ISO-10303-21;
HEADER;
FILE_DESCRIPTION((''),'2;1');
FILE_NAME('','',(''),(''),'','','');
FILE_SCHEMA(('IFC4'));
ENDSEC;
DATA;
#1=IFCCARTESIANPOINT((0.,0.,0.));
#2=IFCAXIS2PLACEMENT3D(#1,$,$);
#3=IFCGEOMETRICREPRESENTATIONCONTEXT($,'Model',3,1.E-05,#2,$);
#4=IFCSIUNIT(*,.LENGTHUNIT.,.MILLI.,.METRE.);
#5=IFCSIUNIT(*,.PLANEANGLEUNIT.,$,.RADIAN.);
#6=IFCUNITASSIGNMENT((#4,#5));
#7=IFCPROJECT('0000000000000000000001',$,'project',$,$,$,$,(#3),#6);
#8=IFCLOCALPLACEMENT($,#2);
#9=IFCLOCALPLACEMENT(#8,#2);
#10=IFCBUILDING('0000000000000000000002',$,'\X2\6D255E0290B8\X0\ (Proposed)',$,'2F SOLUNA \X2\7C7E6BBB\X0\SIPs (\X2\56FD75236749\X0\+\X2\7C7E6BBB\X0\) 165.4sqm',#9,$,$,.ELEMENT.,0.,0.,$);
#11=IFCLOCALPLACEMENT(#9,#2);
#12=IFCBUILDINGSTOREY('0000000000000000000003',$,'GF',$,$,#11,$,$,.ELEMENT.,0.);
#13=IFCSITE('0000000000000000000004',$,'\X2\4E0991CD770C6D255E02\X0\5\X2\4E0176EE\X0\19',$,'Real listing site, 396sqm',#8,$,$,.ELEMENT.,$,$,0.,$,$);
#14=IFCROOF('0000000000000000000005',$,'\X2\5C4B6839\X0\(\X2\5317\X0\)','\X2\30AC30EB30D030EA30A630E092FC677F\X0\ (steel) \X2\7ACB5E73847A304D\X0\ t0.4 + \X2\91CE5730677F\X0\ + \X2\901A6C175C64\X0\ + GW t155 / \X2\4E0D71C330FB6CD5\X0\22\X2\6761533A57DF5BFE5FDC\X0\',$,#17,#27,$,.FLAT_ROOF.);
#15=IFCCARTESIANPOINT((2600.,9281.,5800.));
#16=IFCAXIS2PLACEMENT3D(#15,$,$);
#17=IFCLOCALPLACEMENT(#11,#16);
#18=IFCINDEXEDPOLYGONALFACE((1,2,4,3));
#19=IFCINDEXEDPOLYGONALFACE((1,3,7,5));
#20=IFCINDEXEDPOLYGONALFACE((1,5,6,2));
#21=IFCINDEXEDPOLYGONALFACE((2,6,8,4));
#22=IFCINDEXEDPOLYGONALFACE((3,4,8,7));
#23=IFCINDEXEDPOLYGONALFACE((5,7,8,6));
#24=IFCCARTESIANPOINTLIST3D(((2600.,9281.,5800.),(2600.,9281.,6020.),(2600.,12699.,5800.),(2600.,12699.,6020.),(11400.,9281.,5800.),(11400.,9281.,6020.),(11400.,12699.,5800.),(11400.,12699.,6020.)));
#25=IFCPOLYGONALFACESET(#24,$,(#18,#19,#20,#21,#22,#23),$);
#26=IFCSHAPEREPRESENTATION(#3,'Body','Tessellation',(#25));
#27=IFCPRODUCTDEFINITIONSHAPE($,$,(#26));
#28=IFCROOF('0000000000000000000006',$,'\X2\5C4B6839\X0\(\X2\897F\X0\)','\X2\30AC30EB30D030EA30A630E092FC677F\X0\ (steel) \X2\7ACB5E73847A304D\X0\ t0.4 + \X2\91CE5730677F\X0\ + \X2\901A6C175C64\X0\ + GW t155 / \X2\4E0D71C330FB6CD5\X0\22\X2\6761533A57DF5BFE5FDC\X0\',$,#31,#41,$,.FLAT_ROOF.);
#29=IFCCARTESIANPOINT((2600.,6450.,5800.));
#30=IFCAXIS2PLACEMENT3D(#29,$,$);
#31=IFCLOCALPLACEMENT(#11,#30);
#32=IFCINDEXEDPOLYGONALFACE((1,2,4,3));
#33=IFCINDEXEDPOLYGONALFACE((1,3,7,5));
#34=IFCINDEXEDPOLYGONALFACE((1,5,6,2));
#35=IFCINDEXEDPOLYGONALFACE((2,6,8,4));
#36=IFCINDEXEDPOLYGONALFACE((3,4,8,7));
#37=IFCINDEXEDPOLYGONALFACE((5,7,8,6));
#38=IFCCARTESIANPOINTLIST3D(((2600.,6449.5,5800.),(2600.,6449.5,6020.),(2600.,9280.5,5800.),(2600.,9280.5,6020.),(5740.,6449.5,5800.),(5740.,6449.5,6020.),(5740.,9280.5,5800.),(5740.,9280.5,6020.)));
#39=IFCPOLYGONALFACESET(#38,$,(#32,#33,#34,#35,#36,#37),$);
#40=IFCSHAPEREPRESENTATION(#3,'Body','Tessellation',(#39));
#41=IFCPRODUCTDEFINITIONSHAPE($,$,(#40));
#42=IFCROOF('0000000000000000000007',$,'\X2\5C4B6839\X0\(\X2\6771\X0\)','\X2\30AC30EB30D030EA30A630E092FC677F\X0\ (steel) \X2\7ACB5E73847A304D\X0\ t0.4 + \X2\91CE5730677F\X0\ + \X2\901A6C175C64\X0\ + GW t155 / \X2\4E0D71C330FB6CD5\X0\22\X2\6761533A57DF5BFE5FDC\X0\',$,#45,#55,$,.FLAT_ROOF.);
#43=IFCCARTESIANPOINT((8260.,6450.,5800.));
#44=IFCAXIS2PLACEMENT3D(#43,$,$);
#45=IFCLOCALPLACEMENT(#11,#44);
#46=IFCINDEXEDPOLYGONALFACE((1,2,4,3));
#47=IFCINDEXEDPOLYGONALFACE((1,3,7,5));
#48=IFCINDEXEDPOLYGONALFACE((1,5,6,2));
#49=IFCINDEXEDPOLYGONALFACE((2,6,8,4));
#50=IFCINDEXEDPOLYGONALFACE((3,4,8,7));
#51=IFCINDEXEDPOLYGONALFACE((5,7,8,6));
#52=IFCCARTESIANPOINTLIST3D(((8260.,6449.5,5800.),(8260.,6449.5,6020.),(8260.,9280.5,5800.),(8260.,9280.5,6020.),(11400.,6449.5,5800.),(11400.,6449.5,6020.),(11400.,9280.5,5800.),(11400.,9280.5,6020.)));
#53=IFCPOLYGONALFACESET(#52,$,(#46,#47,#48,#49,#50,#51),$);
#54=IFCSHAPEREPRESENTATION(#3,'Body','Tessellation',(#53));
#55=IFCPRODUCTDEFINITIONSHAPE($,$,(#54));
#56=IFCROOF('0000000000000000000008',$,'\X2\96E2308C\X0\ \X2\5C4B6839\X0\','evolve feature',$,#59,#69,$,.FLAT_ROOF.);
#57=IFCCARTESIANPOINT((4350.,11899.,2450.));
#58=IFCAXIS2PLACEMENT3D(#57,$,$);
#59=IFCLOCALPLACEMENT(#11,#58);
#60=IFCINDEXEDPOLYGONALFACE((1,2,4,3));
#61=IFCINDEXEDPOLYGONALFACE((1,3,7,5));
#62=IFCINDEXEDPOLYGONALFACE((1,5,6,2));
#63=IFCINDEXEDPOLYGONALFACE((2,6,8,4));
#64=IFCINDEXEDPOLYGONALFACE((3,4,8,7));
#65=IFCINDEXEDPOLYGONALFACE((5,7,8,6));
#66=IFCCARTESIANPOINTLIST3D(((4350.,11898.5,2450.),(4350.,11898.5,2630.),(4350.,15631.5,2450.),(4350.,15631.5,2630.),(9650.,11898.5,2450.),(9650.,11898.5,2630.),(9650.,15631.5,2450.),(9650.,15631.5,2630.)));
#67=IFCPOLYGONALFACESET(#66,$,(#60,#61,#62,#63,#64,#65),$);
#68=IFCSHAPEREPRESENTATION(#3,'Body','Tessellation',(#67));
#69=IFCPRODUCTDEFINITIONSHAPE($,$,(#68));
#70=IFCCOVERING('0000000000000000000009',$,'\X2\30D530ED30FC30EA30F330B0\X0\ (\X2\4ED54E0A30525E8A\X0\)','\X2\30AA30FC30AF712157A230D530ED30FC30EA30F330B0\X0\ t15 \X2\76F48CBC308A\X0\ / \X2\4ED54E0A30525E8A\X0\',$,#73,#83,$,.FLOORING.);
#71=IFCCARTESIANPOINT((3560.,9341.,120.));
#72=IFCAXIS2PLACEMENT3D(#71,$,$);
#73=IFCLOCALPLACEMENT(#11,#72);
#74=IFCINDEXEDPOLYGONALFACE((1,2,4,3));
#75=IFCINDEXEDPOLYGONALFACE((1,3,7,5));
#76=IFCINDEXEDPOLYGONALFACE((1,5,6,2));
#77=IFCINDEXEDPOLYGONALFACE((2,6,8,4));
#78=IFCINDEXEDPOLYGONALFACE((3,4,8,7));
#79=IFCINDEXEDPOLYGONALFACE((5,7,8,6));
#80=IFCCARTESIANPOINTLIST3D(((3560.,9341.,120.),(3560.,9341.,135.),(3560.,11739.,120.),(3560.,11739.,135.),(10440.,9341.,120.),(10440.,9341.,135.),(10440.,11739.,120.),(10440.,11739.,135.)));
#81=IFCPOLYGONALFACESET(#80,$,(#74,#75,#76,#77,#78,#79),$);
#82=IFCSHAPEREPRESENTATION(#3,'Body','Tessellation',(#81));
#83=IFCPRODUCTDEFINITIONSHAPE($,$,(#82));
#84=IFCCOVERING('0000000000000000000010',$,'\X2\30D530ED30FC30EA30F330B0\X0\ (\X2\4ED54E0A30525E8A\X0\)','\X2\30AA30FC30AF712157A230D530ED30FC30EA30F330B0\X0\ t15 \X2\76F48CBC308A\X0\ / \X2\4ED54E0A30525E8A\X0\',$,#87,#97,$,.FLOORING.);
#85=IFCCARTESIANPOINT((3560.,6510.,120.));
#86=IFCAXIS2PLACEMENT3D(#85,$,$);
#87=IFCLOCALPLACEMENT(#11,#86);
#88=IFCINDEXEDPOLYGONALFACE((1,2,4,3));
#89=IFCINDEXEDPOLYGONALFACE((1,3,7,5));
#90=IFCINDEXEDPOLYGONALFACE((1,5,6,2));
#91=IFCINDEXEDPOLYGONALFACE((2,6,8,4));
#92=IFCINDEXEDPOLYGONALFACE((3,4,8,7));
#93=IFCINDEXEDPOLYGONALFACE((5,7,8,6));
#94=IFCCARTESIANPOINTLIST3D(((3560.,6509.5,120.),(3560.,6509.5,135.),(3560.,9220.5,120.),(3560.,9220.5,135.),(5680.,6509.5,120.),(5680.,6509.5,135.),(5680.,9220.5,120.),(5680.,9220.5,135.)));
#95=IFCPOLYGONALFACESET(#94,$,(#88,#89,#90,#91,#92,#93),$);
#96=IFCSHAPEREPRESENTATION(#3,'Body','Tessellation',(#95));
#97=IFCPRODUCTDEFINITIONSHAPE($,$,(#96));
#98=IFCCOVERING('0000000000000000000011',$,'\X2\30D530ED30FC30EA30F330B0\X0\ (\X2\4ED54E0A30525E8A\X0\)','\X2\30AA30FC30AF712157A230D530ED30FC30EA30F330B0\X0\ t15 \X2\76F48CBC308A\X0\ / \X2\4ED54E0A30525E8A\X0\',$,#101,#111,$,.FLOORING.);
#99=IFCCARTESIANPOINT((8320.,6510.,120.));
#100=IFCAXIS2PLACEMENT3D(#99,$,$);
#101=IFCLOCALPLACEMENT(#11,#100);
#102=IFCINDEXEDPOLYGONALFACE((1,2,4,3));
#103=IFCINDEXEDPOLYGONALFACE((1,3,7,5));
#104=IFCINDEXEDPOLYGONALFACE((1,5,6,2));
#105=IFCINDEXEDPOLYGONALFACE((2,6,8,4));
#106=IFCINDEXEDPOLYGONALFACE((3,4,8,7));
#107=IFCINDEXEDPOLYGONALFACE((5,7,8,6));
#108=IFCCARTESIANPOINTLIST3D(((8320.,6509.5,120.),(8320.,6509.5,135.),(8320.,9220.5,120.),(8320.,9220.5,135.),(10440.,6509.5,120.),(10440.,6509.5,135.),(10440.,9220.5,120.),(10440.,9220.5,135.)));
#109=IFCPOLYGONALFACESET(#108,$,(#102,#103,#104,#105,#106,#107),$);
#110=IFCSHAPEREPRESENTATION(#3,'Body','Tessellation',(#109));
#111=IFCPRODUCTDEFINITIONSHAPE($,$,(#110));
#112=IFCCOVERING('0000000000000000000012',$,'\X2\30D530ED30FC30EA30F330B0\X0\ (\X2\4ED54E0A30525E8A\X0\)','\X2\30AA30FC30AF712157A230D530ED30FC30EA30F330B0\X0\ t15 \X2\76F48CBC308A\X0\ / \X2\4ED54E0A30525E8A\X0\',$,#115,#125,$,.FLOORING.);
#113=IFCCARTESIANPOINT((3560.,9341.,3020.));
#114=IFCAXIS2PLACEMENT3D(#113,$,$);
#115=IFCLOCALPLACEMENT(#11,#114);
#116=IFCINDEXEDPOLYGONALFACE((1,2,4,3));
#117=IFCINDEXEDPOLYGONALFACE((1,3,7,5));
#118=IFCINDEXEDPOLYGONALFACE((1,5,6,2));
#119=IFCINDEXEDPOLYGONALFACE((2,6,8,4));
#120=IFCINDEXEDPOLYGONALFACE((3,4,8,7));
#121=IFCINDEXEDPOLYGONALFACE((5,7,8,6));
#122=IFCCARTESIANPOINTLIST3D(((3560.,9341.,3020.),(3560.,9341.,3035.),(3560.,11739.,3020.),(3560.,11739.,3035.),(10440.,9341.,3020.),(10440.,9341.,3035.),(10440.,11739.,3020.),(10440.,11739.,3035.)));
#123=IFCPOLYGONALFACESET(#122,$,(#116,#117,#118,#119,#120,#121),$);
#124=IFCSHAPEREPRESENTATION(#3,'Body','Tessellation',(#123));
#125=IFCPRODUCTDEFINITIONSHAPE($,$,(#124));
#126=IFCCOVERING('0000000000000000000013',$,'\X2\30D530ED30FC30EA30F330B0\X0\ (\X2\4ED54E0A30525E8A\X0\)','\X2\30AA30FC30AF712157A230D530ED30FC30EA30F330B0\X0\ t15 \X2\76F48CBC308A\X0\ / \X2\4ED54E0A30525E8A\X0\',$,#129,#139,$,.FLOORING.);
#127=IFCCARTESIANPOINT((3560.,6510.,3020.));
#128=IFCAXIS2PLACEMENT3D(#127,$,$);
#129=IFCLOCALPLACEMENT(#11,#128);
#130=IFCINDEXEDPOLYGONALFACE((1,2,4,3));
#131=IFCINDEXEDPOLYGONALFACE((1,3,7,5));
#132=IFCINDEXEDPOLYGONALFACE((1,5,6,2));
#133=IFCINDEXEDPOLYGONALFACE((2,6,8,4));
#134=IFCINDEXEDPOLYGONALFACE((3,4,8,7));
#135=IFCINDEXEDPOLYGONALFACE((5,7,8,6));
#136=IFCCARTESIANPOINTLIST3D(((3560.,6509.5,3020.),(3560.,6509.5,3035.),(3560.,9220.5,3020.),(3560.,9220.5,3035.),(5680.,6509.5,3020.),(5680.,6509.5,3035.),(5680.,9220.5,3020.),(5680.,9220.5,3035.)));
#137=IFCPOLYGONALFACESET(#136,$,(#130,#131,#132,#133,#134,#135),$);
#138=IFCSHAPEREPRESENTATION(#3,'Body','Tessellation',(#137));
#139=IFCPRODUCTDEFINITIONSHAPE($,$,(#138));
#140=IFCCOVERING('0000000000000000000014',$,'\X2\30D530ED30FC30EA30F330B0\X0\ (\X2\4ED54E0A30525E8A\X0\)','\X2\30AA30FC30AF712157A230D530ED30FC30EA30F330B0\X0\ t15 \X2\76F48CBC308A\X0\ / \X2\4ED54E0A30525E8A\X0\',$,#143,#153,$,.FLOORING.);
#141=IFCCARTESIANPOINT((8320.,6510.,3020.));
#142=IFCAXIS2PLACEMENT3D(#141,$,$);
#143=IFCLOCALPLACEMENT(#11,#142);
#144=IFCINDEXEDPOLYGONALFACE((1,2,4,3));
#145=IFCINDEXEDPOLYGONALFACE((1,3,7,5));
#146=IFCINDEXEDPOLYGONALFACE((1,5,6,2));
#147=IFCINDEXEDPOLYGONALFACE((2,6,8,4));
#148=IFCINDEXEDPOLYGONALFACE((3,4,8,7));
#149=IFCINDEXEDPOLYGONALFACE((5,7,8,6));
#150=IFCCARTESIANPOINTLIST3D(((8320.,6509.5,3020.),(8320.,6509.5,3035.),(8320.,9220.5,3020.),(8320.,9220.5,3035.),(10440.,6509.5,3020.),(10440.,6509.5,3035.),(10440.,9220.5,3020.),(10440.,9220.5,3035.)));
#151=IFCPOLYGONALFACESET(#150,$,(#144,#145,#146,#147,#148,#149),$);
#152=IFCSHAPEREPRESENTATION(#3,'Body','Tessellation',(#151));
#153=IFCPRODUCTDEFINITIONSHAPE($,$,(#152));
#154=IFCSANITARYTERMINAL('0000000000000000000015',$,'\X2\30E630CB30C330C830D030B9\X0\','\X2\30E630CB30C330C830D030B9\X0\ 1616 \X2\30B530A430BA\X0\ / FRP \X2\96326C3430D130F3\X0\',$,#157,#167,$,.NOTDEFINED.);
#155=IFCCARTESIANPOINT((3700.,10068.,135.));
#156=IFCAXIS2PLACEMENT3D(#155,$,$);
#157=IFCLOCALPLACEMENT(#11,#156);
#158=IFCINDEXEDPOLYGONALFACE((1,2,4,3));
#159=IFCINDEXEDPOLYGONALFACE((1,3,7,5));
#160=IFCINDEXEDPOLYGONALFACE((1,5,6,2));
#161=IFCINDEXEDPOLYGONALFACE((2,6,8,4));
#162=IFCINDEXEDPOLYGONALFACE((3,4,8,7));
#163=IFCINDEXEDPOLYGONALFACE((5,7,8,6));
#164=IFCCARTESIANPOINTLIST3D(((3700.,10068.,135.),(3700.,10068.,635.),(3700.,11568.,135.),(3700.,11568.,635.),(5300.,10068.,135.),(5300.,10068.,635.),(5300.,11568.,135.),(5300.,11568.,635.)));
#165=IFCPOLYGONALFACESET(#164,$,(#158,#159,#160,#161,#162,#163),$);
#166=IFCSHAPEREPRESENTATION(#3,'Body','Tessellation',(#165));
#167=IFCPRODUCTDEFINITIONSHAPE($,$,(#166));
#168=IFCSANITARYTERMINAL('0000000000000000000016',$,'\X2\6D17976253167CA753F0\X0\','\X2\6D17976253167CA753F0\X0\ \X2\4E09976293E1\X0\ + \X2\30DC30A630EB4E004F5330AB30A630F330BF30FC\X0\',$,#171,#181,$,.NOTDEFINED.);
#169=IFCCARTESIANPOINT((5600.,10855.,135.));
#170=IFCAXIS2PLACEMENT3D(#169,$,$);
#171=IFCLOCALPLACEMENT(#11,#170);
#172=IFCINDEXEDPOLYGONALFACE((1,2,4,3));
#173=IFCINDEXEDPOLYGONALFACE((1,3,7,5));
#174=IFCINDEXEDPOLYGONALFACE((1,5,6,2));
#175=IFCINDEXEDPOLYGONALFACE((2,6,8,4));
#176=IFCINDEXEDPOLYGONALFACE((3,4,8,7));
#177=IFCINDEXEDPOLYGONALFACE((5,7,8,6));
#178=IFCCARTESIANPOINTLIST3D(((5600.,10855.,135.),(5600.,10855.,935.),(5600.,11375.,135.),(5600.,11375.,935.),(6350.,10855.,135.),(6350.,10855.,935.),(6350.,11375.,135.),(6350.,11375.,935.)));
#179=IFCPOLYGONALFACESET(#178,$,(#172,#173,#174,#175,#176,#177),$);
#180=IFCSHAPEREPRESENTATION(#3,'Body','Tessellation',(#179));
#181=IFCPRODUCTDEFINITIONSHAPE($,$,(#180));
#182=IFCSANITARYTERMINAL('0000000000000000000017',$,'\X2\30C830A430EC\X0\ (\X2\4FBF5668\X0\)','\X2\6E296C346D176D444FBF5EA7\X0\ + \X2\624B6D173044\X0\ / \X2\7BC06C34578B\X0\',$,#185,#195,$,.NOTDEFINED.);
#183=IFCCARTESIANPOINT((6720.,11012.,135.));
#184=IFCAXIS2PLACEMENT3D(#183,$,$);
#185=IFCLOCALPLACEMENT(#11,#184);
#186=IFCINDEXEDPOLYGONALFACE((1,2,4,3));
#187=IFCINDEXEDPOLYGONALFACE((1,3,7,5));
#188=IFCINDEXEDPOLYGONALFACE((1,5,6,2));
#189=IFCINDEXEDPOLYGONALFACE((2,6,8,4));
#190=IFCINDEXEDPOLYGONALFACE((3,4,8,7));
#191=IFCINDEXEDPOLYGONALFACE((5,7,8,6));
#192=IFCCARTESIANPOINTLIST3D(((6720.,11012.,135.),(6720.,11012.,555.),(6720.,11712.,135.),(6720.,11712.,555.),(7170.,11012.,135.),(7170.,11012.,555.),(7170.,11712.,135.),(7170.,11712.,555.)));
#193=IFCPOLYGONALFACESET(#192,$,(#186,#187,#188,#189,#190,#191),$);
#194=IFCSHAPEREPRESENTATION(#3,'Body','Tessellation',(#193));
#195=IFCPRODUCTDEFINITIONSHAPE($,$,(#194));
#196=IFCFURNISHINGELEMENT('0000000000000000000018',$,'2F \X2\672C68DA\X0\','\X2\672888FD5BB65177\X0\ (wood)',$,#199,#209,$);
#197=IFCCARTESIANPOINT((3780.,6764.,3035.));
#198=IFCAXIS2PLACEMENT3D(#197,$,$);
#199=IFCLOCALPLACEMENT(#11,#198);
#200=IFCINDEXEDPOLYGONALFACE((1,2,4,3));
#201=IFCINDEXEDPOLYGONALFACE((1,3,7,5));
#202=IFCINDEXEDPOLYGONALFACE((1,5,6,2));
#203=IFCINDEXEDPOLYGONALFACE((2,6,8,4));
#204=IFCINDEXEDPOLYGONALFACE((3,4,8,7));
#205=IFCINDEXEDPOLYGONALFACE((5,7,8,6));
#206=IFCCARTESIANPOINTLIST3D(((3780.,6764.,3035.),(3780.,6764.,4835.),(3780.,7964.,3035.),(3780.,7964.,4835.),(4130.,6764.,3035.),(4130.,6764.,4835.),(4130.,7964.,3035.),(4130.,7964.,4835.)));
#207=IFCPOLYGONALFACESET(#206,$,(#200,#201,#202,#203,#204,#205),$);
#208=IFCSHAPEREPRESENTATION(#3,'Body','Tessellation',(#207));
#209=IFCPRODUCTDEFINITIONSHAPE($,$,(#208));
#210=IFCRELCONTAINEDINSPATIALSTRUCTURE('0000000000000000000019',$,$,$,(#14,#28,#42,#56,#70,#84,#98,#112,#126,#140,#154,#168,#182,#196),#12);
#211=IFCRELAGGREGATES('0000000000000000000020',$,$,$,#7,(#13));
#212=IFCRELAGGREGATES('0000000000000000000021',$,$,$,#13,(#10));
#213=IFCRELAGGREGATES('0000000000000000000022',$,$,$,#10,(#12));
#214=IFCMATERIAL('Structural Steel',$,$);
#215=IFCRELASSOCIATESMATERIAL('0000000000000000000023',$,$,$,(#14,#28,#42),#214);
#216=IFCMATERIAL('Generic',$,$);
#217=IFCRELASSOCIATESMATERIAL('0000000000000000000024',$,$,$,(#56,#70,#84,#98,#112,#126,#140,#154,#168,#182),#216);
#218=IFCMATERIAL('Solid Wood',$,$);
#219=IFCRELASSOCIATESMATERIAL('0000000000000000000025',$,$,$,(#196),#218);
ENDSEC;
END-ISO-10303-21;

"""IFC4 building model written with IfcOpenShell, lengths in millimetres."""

from ifc_helpers import new_model, si_unit, frame, frame_2d, origin, place, context, project, spatial, rectangle, extrude, material, element, save


model = new_model("IFC4")

# Units and contexts
model_context = context("Model", 3, precision=1e-05, world=origin())
ifc_project = project(units=[si_unit("LENGTHUNIT", "METRE", prefix="MILLI"), si_unit("PLANEANGLEUNIT", "RADIAN")], contexts=[model_context])

# Site, building, storey
site_placement = place(None, origin())
site = spatial("IfcSite", under=ifc_project, at=site_placement, Name="三重県津市5丁目19", ObjectType="Real listing site, 396sqm", CompositionType="ELEMENT", RefElevation=0.0)
building_placement = place(site_placement, origin())
building = spatial("IfcBuilding", under=site, at=building_placement, Name="津市邸 (Proposed)", ObjectType="2F SOLUNA 籾殻SIPs (国産杉+籾殻) 165.4sqm", CompositionType="ELEMENT", ElevationOfRefHeight=0.0, ElevationOfTerrain=0.0)
storey_placement = place(building_placement, origin())
storey = spatial("IfcBuildingStorey", under=building, at=storey_placement, Name="GF", CompositionType="ELEMENT", Elevation=0.0)

# Shared definitions
ifc_material_1 = material(Name="Solid Wood")
ifc_material_2 = material(Name="Generic")

# Roofs
ifc_material_3 = material(Name="Structural Steel")
for number, where, name in (
    (1, (2600.0, 9281.0, 5800.0), "屋根(北)"),
):
    element("IfcRoof", number, at=place(storey_placement, frame(where)), inside=storey, material=ifc_material_3, Name=name, Description="ガルバリウム鋼板 (steel) 立平葺き t0.4 + 野地板 + 通気層 + GW t155 / 不燃・法22条区域対応", PredefinedType="FLAT_ROOF", context=model_context, shape_type="SweptSolid", body=[
        extrude(rectangle(XDim=8800.0, YDim=3418.0, at=frame_2d((4400.0, 1709.0))), frame((2600.0, 9281.0, 5800.0)), (0.0, 0.0, 1.0), 220.0),
    ])
roof_1_placement = place(storey_placement, frame((2600.0, 6450.0, 5800.0)))
element("IfcRoof", 2, at=roof_1_placement, inside=storey, material=ifc_material_3, Name="屋根(西)", Description="ガルバリウム鋼板 (steel) 立平葺き t0.4 + 野地板 + 通気層 + GW t155 / 不燃・法22条区域対応", PredefinedType="FLAT_ROOF", context=model_context, shape_type="SweptSolid", body=[
    extrude(rectangle(XDim=3140.0, YDim=2831.0, at=frame_2d((1570.0, 1415.0))), frame((2600.0, 6450.0, 5800.0)), (0.0, 0.0, 1.0), 220.0),
])
roof_2_placement = place(storey_placement, frame((8260.0, 6450.0, 5800.0)))
element("IfcRoof", 3, at=roof_2_placement, inside=storey, material=ifc_material_3, Name="屋根(東)", Description="ガルバリウム鋼板 (steel) 立平葺き t0.4 + 野地板 + 通気層 + GW t155 / 不燃・法22条区域対応", PredefinedType="FLAT_ROOF", context=model_context, shape_type="SweptSolid", body=[
    extrude(rectangle(XDim=3140.0, YDim=2831.0, at=frame_2d((1570.0, 1415.0))), frame((8260.0, 6450.0, 5800.0)), (0.0, 0.0, 1.0), 220.0),
])
roof_3_placement = place(storey_placement, frame((4350.0, 11899.0, 2450.0)))
element("IfcRoof", 4, at=roof_3_placement, inside=storey, material=ifc_material_2, Name="離れ 屋根", Description="evolve feature", PredefinedType="FLAT_ROOF", context=model_context, shape_type="SweptSolid", body=[
    extrude(rectangle(XDim=5300.0, YDim=3733.0, at=frame_2d((2650.0, 1866.0))), frame((4350.0, 11899.0, 2450.0)), (0.0, 0.0, 1.0), 180.0),
])

# Coverings
covering_1_placement = place(storey_placement, frame((3560.0, 9341.0, 120.0)))
element("IfcCovering", 5, at=covering_1_placement, inside=storey, material=ifc_material_2, Name="フローリング (仕上げ床)", Description="オーク無垢フローリング t15 直貼り / 仕上げ床", PredefinedType="FLOORING", context=model_context, shape_type="SweptSolid", body=[
    extrude(rectangle(XDim=6880.0, YDim=2398.0, at=frame_2d((3440.0, 1199.0))), frame((3560.0, 9341.0, 120.0)), (0.0, 0.0, 1.0), 15.0),
])
covering_2_placement = place(storey_placement, frame((3560.0, 6510.0, 120.0)))
element("IfcCovering", 6, at=covering_2_placement, inside=storey, material=ifc_material_2, Name="フローリング (仕上げ床)", Description="オーク無垢フローリング t15 直貼り / 仕上げ床", PredefinedType="FLOORING", context=model_context, shape_type="SweptSolid", body=[
    extrude(rectangle(XDim=2120.0, YDim=2711.0, at=frame_2d((1060.0, 1355.0))), frame((3560.0, 6510.0, 120.0)), (0.0, 0.0, 1.0), 15.0),
])
covering_3_placement = place(storey_placement, frame((8320.0, 6510.0, 120.0)))
element("IfcCovering", 7, at=covering_3_placement, inside=storey, material=ifc_material_2, Name="フローリング (仕上げ床)", Description="オーク無垢フローリング t15 直貼り / 仕上げ床", PredefinedType="FLOORING", context=model_context, shape_type="SweptSolid", body=[
    extrude(rectangle(XDim=2120.0, YDim=2711.0, at=frame_2d((1060.0, 1355.0))), frame((8320.0, 6510.0, 120.0)), (0.0, 0.0, 1.0), 15.0),
])
covering_4_placement = place(storey_placement, frame((3560.0, 9341.0, 3020.0)))
element("IfcCovering", 8, at=covering_4_placement, inside=storey, material=ifc_material_2, Name="フローリング (仕上げ床)", Description="オーク無垢フローリング t15 直貼り / 仕上げ床", PredefinedType="FLOORING", context=model_context, shape_type="SweptSolid", body=[
    extrude(rectangle(XDim=6880.0, YDim=2398.0, at=frame_2d((3440.0, 1199.0))), frame((3560.0, 9341.0, 3020.0)), (0.0, 0.0, 1.0), 15.0),
])
covering_5_placement = place(storey_placement, frame((3560.0, 6510.0, 3020.0)))
element("IfcCovering", 9, at=covering_5_placement, inside=storey, material=ifc_material_2, Name="フローリング (仕上げ床)", Description="オーク無垢フローリング t15 直貼り / 仕上げ床", PredefinedType="FLOORING", context=model_context, shape_type="SweptSolid", body=[
    extrude(rectangle(XDim=2120.0, YDim=2711.0, at=frame_2d((1060.0, 1355.0))), frame((3560.0, 6510.0, 3020.0)), (0.0, 0.0, 1.0), 15.0),
])
covering_6_placement = place(storey_placement, frame((8320.0, 6510.0, 3020.0)))
element("IfcCovering", 10, at=covering_6_placement, inside=storey, material=ifc_material_2, Name="フローリング (仕上げ床)", Description="オーク無垢フローリング t15 直貼り / 仕上げ床", PredefinedType="FLOORING", context=model_context, shape_type="SweptSolid", body=[
    extrude(rectangle(XDim=2120.0, YDim=2711.0, at=frame_2d((1060.0, 1355.0))), frame((8320.0, 6510.0, 3020.0)), (0.0, 0.0, 1.0), 15.0),
])

# Sanitary terminals
sanitary_terminal_1_placement = place(storey_placement, frame((3700.0, 10068.0, 135.0)))
element("IfcSanitaryTerminal", 11, at=sanitary_terminal_1_placement, inside=storey, material=ifc_material_2, Name="ユニットバス", Description="ユニットバス 1616 サイズ / FRP 防水パン", PredefinedType="NOTDEFINED", context=model_context, shape_type="SweptSolid", body=[
    extrude(rectangle(XDim=1600.0, YDim=1500.0, at=frame_2d((800.0, 750.0))), frame((3700.0, 10068.0, 135.0)), (0.0, 0.0, 1.0), 500.0),
])
sanitary_terminal_2_placement = place(storey_placement, frame((5600.0, 10855.0, 135.0)))
element("IfcSanitaryTerminal", 12, at=sanitary_terminal_2_placement, inside=storey, material=ifc_material_2, Name="洗面化粧台", Description="洗面化粧台 三面鏡 + ボウル一体カウンター", PredefinedType="NOTDEFINED", context=model_context, shape_type="SweptSolid", body=[
    extrude(rectangle(XDim=750.0, YDim=520.0, at=frame_2d((375.0, 260.0))), frame((5600.0, 10855.0, 135.0)), (0.0, 0.0, 1.0), 800.0),
])
sanitary_terminal_3_placement = place(storey_placement, frame((6720.0, 11012.0, 135.0)))
element("IfcSanitaryTerminal", 13, at=sanitary_terminal_3_placement, inside=storey, material=ifc_material_2, Name="トイレ (便器)", Description="温水洗浄便座 + 手洗い / 節水型", PredefinedType="NOTDEFINED", context=model_context, shape_type="SweptSolid", body=[
    extrude(rectangle(XDim=450.0, YDim=700.0, at=frame_2d((225.0, 350.0))), frame((6720.0, 11012.0, 135.0)), (0.0, 0.0, 1.0), 420.0),
])

# Furnishing element
furnishing_placement = place(storey_placement, frame((3780.0, 6764.0, 3035.0)))
element("IfcFurnishingElement", 14, at=furnishing_placement, inside=storey, material=ifc_material_1, Name="2F 本棚", Description="木製家具 (wood)", context=model_context, shape_type="SweptSolid", body=[
    extrude(rectangle(XDim=350.0, YDim=1200.0, at=frame_2d((175.0, 600.0))), frame((3780.0, 6764.0, 3035.0)), (0.0, 0.0, 1.0), 1800.0),
])

save(model, "model.ifc")
